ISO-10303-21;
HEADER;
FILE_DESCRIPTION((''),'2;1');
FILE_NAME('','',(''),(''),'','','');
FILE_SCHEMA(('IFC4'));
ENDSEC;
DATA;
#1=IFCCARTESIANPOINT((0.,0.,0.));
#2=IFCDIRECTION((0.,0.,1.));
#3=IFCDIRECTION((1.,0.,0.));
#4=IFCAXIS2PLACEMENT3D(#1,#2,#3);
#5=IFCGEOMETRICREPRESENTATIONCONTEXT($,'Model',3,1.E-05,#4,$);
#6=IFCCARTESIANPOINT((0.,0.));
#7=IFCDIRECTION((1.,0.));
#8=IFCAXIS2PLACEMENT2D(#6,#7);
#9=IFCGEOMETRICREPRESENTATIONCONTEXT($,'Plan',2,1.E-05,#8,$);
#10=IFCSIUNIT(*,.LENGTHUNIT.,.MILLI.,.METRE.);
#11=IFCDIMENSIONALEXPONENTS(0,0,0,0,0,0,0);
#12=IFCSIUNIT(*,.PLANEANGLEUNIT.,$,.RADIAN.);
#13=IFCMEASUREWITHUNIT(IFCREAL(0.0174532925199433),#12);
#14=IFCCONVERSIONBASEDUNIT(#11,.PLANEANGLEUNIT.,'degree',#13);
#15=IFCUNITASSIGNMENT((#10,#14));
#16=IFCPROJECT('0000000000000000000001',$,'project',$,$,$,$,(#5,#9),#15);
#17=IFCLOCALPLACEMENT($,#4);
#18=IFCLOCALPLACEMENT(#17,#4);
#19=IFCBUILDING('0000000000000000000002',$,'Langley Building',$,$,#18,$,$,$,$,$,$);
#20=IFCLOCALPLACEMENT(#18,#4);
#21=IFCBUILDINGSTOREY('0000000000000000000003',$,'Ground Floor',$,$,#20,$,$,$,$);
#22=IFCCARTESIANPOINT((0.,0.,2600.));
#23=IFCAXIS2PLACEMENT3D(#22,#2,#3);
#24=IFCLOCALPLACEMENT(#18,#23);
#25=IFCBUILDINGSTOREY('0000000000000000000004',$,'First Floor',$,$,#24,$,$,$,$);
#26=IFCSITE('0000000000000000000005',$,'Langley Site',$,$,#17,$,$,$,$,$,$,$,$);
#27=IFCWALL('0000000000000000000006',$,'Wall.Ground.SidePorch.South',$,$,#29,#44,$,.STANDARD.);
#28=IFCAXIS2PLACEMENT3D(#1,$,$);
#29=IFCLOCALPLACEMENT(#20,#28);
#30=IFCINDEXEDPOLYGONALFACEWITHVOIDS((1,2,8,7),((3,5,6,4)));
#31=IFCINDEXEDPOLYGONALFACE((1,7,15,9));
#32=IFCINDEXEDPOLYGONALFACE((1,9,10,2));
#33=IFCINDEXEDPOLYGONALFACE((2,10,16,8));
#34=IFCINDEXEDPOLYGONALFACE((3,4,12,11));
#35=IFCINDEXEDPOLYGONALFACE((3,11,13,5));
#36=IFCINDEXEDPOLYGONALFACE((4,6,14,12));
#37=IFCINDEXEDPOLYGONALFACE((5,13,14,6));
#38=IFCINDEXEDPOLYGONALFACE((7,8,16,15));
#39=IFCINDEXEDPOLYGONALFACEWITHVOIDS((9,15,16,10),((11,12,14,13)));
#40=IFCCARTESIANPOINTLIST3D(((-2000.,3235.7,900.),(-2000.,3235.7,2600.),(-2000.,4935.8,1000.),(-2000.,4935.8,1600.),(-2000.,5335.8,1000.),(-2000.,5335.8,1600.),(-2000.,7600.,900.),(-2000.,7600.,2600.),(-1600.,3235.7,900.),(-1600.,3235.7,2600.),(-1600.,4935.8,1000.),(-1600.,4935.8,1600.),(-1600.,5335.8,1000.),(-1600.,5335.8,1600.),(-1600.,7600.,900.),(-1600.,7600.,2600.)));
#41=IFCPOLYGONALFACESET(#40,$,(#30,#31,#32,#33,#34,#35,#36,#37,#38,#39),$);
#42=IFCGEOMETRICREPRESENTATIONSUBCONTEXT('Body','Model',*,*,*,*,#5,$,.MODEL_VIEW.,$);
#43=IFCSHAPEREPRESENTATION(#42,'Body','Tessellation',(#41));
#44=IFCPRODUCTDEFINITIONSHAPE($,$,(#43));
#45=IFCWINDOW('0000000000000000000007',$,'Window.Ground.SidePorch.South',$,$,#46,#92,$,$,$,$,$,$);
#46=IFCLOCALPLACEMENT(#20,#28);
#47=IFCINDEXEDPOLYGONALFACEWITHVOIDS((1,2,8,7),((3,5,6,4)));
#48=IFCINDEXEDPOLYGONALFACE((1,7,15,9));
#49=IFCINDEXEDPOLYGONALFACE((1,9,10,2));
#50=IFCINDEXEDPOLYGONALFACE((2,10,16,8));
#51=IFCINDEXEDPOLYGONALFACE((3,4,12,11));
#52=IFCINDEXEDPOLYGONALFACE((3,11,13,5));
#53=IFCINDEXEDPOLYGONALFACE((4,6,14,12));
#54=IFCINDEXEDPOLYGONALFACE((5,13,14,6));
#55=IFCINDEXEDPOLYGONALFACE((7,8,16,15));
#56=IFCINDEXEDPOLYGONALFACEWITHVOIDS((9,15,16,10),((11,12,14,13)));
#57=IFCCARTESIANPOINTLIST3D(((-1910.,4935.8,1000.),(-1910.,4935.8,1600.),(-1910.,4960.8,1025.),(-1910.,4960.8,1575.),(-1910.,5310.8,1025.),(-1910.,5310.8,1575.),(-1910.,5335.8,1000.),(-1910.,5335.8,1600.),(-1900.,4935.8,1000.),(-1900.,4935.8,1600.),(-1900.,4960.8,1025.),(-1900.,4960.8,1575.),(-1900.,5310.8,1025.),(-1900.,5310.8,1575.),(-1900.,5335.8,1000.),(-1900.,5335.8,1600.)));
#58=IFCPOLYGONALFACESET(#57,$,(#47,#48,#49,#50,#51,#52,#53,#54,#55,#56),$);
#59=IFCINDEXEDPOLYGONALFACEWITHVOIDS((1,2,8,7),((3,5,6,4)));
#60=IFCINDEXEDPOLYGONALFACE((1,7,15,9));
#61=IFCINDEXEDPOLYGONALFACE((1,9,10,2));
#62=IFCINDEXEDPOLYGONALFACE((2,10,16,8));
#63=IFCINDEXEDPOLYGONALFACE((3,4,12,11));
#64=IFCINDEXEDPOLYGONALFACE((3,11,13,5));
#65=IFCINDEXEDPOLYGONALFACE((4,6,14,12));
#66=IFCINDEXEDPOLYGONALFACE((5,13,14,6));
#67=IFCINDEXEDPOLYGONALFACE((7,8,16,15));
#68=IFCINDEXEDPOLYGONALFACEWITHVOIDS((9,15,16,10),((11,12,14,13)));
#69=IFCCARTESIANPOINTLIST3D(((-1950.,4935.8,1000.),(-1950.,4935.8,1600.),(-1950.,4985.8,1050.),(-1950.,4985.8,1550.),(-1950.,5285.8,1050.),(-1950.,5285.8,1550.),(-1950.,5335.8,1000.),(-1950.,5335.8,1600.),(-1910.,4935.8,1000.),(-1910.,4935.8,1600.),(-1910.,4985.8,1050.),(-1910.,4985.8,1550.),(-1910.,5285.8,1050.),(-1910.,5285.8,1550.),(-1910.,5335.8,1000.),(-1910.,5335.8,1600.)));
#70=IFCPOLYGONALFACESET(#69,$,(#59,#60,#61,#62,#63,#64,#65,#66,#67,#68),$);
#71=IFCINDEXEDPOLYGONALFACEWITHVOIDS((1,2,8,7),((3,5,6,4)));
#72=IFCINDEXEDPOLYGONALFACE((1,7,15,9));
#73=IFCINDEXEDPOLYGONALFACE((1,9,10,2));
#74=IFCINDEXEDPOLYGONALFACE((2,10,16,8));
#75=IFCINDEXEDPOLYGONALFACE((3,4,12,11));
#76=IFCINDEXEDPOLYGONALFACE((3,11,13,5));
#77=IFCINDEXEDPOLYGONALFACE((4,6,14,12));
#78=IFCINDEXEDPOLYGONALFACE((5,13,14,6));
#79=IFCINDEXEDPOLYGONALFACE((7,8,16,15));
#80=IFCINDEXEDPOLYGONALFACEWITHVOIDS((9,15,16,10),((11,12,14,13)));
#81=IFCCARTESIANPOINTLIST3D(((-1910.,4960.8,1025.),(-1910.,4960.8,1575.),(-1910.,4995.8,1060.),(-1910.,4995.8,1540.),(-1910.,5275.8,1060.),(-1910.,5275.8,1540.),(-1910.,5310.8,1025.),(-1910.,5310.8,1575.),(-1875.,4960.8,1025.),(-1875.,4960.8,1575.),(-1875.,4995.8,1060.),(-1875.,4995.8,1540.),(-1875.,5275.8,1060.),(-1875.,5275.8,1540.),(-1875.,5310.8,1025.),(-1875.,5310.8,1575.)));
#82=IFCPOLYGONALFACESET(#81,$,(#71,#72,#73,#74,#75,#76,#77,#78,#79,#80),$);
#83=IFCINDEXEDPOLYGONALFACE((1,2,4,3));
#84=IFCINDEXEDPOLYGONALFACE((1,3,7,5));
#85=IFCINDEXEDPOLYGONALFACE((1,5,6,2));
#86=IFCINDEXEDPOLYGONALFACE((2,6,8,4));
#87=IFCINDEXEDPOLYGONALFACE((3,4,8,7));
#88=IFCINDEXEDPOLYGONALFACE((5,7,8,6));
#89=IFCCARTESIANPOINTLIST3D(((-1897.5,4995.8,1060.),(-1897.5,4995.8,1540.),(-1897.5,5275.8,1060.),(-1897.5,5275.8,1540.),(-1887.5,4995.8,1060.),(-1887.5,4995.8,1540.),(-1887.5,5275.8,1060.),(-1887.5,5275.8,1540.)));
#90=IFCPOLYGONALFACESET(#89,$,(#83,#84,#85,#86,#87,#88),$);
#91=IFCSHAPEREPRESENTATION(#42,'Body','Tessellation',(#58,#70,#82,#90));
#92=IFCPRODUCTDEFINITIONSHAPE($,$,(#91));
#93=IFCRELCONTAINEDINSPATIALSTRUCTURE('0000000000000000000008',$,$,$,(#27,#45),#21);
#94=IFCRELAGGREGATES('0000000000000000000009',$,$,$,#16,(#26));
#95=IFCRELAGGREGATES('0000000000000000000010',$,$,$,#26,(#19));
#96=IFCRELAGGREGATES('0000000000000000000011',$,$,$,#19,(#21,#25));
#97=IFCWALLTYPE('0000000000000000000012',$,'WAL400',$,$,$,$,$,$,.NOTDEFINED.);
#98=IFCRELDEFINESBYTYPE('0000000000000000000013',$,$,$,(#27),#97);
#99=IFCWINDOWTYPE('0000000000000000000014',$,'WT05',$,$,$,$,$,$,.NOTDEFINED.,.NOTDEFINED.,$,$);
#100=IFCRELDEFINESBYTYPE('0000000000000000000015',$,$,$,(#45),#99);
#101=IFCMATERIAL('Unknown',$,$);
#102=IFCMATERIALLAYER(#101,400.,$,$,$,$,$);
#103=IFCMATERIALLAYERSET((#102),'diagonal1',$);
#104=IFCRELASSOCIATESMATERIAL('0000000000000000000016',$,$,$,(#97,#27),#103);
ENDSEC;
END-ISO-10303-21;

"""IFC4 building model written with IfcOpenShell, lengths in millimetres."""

from ifc_helpers import new_model, entity, si_unit, converted_unit, frame, origin_with_axes, origin_2d_with_axis, place, context, subcontext, project, spatial, line, indexed_curve, outline, extrude, shape, source, transform, mapped, material, layer, layer_set, layer_usage, type_object, type_shapes, element, fill, save


model = new_model("IFC4")

# Units and contexts
model_context = context("Model", 3, precision=1e-05, world=origin_with_axes())
plan_context = context("Plan", 2, precision=1e-05, world=origin_2d_with_axis())
body_context_1 = subcontext(model_context, "Body", "Model", "MODEL_VIEW")
body_context_2 = subcontext(plan_context, "Body", "Plan", "PLAN_VIEW")
ifc_project = project(units=[si_unit("LENGTHUNIT", "METRE", prefix="MILLI"), converted_unit("PLANEANGLEUNIT", "degree", entity("IfcReal", 0.0174532925199433), si_unit("PLANEANGLEUNIT", "RADIAN"), dimensions=[0, 0, 0, 0, 0, 0, 0])], contexts=[model_context, plan_context])

# Site, building, storey
site_placement = place(None, origin_with_axes())
site = spatial("IfcSite", under=ifc_project, at=site_placement, Name="Langley Site")
building_placement = place(site_placement, origin_with_axes())
building = spatial("IfcBuilding", under=site, at=building_placement, Name="Langley Building")
storey_1_placement = place(building_placement, origin_with_axes())
storey_1 = spatial("IfcBuildingStorey", under=building, at=storey_1_placement, Name="Ground Floor")

# Shared definitions
ifc_material = material(Name="Unknown")

# Shared definitions
storey_2_placement = place(building_placement, frame((0.0, 0.0, 2600.0), z_axis=(0.0, 0.0, 1.0), x_axis=(1.0, 0.0, 0.0)))
storey_2 = spatial("IfcBuildingStorey", under=building, at=storey_2_placement, Name="First Floor")

# Shared definitions
ifc_layer_1 = layer(ifc_material, 400.0)
ifc_layer_set_1 = layer_set([ifc_layer_1], Name="diagonal1")
wall_type_1 = type_object("IfcWallType", Name="WAL400", PredefinedType="NOTDEFINED", material=ifc_layer_set_1)

# Wall, opening, window
ifc_layer_usage_1 = layer_usage(ifc_layer_set_1, "AXIS2", "POSITIVE", 0.0)
wall_1_placement = place(storey_1_placement, frame((-2000.0, 7600.0, 900.0), z_axis=(0.0, 0.0, 1.0), x_axis=(0.0, -1.0, 0.0)))
wall_1 = element("IfcWall", 1, at=wall_1_placement, inside=storey_1, type_object=wall_type_1, material=ifc_layer_usage_1, Name="Wall.Ground.SidePorch.South", PredefinedType="STANDARD", context=body_context_1, shape_type="SweptSolid", body=[
    extrude(outline(indexed_curve([(0.0, 0.0), (0.0, 400.0), (4364.3, 400.0), (4364.3, 0.0)], segments=[line(1, 2, 3, 4, 1)])), origin_with_axes(), (0.0, 0.0, 1.0), 1700.0),
])
shared_shape_1 = source(origin_with_axes(), body_context_1, "Body", "SweptSolid", [
    extrude(outline(indexed_curve([(0.0, 0.0), (400.0, 0.0), (400.0, 600.0), (0.0, 600.0)], segments=[line(1, 2, 3, 4, 1)])), frame((0.0, -600.0, 0.0), z_axis=(0.0, -1.0, 0.0), x_axis=(1.0, 0.0, 0.0)), (0.0, 0.0, -1.0), 1200.0),
])
opening_1_placement = place(wall_1_placement, frame((2264.2, 0.0, 100.0), z_axis=(0.0, 0.0, 1.0), x_axis=(1.0, 0.0, 0.0)))
opening_1 = element("IfcOpeningElement", 2, at=opening_1_placement, cuts=wall_1, PredefinedType="OPENING", context=body_context_1, shape_type="MappedRepresentation", body=[
    mapped(shared_shape_1, transform((0.0, 0.0, 0.0), x_axis=(1.0, 0.0, 0.0), y_axis=(0.0, 1.0, 0.0), z_axis=(0.0, 0.0, 1.0), scale=1.0)),
])
window_type_1 = type_object("IfcWindowType", Name="WT05", PartitioningType="NOTDEFINED", PredefinedType="NOTDEFINED")
shared_shape_2 = source(origin_with_axes(), body_context_1, "Body", "SweptSolid", [
    extrude(outline(indexed_curve([(0.0, 0.0), (400.0, 0.0), (400.0, 600.0), (0.0, 600.0)], segments=[line(1, 2, 3, 4, 1)]), holes=[indexed_curve([(25.0, 25.0), (375.0, 25.0), (375.0, 575.0), (25.0, 575.0)], segments=[line(1, 2, 3, 4, 1)])]), frame((0.0, 90.0, 0.0), z_axis=(0.0, -1.0, 0.0), x_axis=(1.0, 0.0, 0.0)), (0.0, 0.0, -1.0), 10.0),
    extrude(outline(indexed_curve([(0.0, 0.0), (400.0, 0.0), (400.0, 600.0), (0.0, 600.0)], segments=[line(1, 2, 3, 4, 1)]), holes=[indexed_curve([(50.0, 50.0), (350.0, 50.0), (350.0, 550.0), (50.0, 550.0)], segments=[line(1, 2, 3, 4, 1)])]), frame((0.0, 50.0, 0.0), z_axis=(0.0, -1.0, 0.0), x_axis=(1.0, 0.0, 0.0)), (0.0, 0.0, -1.0), 40.0),
    extrude(outline(indexed_curve([(0.0, 0.0), (350.0, 0.0), (350.0, 550.0), (0.0, 550.0)], segments=[line(1, 2, 3, 4, 1)]), holes=[indexed_curve([(35.0, 35.0), (315.0, 35.0), (315.0, 515.0), (35.0, 515.0)], segments=[line(1, 2, 3, 4, 1)])]), frame((25.0, 90.0, 25.0), z_axis=(0.0, -1.0, 0.0), x_axis=(1.0, 0.0, 0.0)), (0.0, 0.0, -1.0), 35.0),
    extrude(outline(indexed_curve([(35.0, 35.0), (315.0, 35.0), (315.0, 515.0), (35.0, 515.0)], segments=[line(1, 2, 3, 4, 1)])), frame((25.0, 102.5, 25.0), z_axis=(0.0, -1.0, 0.0), x_axis=(1.0, 0.0, 0.0)), (0.0, 0.0, -1.0), 10.0),
])
shared_shape_3 = source(origin_with_axes(), body_context_2, "Body", "Curve2D", [
    entity("IfcIndexedPolyCurve", entity("IfcCartesianPointList2D", [[50.0, 50.0], [350.0, 50.0]])),
    entity("IfcIndexedPolyCurve", entity("IfcCartesianPointList2D", [[0.0, 100.0], [25.0, 100.0], [25.0, 90.0], [50.0, 90.0], [50.0, 50.0], [0.0, 50.0]]), [entity("IfcLineIndex", [1, 2, 3, 4, 5, 6, 1])]),
    entity("IfcIndexedPolyCurve", entity("IfcCartesianPointList2D", [[400.0, 100.0], [375.0, 100.0], [375.0, 90.0], [350.0, 90.0], [350.0, 50.0], [400.0, 50.0]]), [entity("IfcLineIndex", [1, 2, 3, 4, 5, 6, 1])]),
    entity("IfcIndexedPolyCurve", entity("IfcCartesianPointList2D", [[25.0, 90.0], [60.0, 90.0], [60.0, 125.0], [25.0, 125.0]]), [entity("IfcLineIndex", [1, 2, 3, 4, 1])]),
    entity("IfcIndexedPolyCurve", entity("IfcCartesianPointList2D", [[375.0, 90.0], [340.0, 90.0], [340.0, 125.0], [375.0, 125.0]]), [entity("IfcLineIndex", [1, 2, 3, 4, 1])]),
    entity("IfcIndexedPolyCurve", entity("IfcCartesianPointList2D", [[60.0, 90.0], [340.0, 90.0]])),
    entity("IfcIndexedPolyCurve", entity("IfcCartesianPointList2D", [[60.0, 125.0], [340.0, 125.0]])),
    entity("IfcIndexedPolyCurve", entity("IfcCartesianPointList2D", [[60.0, 107.5], [340.0, 107.5]])),
])
type_shapes(window_type_1, [shared_shape_2, shared_shape_3])
window_1_placement = place(opening_1_placement, frame((0.0, 0.0, 0.0), z_axis=(0.0, 0.0, 1.0), x_axis=(1.0, 0.0, 0.0)))
window_1 = element("IfcWindow", 3, at=window_1_placement, inside=storey_1, type_object=window_type_1, Name="Window.Ground.SidePorch.South", shapes=[
    shape(body_context_1, "Body", "MappedRepresentation", [mapped(shared_shape_2, transform((0.0, 0.0, 0.0), x_axis=(1.0, 0.0, 0.0), y_axis=(0.0, 1.0, 0.0), z_axis=(0.0, 0.0, 1.0), scale=1.0))]),
    shape(body_context_2, "Body", "MappedRepresentation", [mapped(shared_shape_3, transform((0.0, 0.0, 0.0), x_axis=(1.0, 0.0, 0.0), y_axis=(0.0, 1.0, 0.0), z_axis=(0.0, 0.0, 1.0), scale=1.0))]),
])
fill(opening_1, window_1)

save(model, "model.ifc")
